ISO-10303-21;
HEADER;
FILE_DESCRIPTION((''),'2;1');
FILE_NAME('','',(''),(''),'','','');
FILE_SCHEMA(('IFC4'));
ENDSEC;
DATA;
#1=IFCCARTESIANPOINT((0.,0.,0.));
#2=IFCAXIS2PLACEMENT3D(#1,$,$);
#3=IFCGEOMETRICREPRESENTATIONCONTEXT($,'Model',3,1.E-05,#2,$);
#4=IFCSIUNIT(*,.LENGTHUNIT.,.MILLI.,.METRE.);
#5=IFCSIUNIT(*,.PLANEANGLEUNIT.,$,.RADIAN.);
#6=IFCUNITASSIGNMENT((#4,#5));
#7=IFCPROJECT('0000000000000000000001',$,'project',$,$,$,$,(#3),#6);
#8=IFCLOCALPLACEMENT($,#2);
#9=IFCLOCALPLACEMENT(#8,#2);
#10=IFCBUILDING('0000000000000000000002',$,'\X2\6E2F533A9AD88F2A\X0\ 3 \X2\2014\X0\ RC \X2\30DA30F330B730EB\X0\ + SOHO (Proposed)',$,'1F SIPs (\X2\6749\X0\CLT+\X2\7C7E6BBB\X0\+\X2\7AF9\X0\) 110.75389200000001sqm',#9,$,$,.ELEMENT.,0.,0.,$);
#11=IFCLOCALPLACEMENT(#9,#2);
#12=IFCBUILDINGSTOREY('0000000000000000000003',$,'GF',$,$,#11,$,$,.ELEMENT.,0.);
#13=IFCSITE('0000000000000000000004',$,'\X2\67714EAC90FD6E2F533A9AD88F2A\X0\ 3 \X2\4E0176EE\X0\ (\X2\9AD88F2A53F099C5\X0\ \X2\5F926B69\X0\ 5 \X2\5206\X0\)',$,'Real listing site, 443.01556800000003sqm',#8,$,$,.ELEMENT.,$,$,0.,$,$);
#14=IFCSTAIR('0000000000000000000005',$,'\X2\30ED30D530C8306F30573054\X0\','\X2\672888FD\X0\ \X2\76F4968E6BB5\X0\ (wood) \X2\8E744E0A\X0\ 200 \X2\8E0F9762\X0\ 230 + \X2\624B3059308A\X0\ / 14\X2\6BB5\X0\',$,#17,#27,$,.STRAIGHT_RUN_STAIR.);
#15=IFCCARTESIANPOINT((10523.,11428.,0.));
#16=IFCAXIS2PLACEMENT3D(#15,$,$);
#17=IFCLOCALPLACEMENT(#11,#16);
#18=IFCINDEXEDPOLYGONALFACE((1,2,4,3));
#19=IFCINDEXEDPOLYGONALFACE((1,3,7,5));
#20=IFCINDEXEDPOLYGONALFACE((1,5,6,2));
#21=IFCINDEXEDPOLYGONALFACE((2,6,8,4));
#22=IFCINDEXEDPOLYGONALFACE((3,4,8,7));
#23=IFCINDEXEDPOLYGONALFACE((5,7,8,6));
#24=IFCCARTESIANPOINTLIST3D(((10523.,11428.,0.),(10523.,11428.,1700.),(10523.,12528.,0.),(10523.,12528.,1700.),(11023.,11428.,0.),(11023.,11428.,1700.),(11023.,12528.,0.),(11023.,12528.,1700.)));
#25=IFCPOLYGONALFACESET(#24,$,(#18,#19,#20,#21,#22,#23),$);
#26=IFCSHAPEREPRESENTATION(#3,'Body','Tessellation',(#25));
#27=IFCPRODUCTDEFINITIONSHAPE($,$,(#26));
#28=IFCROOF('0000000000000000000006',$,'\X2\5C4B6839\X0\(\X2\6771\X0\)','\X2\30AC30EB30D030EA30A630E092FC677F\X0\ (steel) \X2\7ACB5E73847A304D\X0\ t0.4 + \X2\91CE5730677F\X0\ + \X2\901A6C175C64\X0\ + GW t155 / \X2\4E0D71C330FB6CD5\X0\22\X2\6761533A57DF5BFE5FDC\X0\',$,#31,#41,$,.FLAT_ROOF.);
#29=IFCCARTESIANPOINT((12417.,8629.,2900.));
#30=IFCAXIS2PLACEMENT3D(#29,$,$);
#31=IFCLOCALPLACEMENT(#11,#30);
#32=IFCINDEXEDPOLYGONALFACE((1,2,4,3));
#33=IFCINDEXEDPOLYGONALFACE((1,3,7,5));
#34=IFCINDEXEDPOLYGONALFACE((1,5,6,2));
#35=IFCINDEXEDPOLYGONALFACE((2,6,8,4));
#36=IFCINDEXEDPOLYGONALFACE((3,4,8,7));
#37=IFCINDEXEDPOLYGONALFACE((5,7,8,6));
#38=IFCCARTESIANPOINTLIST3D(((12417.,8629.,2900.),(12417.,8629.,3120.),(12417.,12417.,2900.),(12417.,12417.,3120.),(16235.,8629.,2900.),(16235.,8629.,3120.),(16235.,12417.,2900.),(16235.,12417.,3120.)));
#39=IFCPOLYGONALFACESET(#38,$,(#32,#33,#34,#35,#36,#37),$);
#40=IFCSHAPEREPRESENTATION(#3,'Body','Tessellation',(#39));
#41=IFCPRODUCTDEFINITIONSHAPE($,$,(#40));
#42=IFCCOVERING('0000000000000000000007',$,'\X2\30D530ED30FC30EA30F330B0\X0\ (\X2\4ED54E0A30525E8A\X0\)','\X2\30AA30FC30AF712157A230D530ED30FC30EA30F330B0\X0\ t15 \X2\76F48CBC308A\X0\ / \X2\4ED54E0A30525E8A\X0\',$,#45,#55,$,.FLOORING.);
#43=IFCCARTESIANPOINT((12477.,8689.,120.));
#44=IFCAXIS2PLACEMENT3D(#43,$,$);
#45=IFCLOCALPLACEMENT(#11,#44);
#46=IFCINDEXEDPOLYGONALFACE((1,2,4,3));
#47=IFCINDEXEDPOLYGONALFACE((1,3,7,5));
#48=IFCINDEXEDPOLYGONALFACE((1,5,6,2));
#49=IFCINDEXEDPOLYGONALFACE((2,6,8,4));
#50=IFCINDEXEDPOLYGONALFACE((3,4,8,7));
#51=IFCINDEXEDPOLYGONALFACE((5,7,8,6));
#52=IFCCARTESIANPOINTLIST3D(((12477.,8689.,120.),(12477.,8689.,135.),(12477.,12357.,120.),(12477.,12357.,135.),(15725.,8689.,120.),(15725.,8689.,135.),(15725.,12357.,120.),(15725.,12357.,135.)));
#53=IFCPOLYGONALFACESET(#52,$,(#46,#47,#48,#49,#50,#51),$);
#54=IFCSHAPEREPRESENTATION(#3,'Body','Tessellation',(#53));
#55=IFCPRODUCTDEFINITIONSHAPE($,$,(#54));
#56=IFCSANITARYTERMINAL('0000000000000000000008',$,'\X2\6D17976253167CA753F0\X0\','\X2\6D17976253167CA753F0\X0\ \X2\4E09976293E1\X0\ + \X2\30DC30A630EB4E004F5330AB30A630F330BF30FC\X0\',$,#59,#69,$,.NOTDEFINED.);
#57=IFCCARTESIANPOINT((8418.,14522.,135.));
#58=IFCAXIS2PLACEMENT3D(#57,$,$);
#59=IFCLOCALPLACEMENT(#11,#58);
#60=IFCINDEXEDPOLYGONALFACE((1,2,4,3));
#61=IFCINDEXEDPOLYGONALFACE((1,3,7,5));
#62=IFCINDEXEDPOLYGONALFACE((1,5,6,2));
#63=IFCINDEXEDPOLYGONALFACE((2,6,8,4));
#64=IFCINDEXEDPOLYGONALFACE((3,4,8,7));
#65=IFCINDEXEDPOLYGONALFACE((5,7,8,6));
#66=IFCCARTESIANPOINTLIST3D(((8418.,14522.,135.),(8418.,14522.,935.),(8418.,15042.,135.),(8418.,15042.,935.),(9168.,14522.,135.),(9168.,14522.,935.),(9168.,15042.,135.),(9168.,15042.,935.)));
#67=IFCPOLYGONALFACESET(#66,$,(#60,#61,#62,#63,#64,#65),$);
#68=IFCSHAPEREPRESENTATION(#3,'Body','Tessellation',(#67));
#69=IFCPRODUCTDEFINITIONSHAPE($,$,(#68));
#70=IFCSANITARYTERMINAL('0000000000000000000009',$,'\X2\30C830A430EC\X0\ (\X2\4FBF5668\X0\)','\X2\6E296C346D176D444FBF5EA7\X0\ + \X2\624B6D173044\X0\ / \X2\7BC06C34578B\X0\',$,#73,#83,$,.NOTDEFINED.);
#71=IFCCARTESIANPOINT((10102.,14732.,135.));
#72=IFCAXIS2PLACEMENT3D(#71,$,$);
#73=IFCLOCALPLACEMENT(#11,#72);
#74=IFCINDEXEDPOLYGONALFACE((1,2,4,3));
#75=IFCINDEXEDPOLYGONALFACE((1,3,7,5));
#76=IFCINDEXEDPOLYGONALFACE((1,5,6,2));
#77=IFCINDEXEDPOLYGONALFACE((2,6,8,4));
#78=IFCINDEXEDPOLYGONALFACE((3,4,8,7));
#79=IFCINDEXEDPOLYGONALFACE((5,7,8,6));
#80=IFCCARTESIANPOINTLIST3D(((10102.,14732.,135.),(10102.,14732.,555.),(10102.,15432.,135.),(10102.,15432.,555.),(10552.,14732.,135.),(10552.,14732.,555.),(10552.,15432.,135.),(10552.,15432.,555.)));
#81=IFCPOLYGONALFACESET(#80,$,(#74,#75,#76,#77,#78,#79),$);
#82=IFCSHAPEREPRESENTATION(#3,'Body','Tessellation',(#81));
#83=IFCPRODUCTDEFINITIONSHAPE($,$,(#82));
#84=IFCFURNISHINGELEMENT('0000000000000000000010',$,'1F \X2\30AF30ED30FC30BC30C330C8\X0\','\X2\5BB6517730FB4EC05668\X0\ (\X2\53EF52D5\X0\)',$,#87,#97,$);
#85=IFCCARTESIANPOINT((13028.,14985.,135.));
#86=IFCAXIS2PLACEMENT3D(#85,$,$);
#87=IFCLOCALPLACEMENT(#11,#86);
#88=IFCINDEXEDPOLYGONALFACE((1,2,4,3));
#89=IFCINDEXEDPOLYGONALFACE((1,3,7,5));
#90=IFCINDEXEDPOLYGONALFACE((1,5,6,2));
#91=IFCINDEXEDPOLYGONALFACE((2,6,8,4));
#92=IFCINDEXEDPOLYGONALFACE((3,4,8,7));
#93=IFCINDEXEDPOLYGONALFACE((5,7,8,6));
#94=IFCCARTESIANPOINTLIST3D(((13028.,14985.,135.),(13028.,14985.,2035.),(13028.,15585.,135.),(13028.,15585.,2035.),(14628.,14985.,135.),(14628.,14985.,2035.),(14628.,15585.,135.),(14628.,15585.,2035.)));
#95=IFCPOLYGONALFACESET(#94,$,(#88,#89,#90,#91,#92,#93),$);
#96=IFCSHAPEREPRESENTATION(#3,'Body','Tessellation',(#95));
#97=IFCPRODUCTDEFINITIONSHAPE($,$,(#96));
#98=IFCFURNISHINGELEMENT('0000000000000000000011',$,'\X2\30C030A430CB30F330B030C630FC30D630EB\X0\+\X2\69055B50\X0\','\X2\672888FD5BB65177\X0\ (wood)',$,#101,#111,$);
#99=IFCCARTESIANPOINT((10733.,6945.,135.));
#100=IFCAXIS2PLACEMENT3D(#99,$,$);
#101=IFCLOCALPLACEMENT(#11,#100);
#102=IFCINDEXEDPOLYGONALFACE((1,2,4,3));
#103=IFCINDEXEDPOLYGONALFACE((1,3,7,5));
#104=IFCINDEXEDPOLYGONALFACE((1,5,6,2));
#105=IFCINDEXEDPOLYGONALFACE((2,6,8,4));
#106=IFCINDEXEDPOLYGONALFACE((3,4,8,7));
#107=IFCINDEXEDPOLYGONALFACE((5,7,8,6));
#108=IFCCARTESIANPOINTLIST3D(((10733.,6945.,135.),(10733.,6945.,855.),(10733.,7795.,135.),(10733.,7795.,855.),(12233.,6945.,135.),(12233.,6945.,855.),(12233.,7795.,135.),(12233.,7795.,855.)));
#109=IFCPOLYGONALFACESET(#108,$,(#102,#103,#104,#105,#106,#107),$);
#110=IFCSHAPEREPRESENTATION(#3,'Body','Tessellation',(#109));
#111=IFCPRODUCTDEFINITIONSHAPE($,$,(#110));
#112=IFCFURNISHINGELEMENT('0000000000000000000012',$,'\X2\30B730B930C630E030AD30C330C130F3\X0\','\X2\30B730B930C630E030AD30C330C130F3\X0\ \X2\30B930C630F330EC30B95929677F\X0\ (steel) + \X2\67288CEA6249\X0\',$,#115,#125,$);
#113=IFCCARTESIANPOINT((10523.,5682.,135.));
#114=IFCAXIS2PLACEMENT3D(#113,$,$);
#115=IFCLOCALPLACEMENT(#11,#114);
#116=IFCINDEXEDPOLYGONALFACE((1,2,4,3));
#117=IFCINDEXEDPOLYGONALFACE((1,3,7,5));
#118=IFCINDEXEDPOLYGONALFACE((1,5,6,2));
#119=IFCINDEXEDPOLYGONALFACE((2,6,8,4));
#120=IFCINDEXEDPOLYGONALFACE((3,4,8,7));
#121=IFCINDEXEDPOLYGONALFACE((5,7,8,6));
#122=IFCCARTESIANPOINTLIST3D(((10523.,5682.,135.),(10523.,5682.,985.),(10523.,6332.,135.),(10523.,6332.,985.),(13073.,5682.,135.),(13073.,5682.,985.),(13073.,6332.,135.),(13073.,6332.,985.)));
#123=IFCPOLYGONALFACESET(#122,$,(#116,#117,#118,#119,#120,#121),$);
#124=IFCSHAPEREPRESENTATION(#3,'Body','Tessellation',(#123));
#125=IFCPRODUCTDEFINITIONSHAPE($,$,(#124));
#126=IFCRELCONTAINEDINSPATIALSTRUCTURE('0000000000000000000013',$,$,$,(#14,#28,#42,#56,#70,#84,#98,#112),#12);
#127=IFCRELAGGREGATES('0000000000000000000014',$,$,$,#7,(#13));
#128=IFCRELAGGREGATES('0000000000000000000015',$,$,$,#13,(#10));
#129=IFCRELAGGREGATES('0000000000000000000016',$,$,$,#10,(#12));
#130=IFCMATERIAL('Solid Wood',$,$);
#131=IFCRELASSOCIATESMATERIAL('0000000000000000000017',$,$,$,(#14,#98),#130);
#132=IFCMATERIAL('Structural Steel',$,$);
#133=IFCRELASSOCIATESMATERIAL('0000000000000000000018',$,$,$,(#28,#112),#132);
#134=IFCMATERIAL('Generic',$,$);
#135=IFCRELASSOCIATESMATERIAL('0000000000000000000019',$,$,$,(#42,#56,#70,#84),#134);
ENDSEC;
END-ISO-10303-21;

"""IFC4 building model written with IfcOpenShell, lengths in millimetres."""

from ifc_helpers import new_model, si_unit, frame, frame_2d, origin, place, context, project, spatial, rectangle, extrude, material, element, save


model = new_model("IFC4")

# Units and contexts
model_context = context("Model", 3, precision=1e-05, world=origin())
ifc_project = project(units=[si_unit("LENGTHUNIT", "METRE", prefix="MILLI"), si_unit("PLANEANGLEUNIT", "RADIAN")], contexts=[model_context])

# Site, building, storey
site_placement = place(None, origin())
site = spatial("IfcSite", under=ifc_project, at=site_placement, Name="東京都港区高輪 3 丁目 (高輪台駅 徒歩 5 分)", ObjectType="Real listing site, 443.01556800000003sqm", CompositionType="ELEMENT", RefElevation=0.0)
building_placement = place(site_placement, origin())
building = spatial("IfcBuilding", under=site, at=building_placement, Name="港区高輪 3 — RC ペンシル + SOHO (Proposed)", ObjectType="1F SIPs (杉CLT+籾殻+竹) 110.75389200000001sqm", CompositionType="ELEMENT", ElevationOfRefHeight=0.0, ElevationOfTerrain=0.0)
storey_placement = place(building_placement, origin())
storey = spatial("IfcBuildingStorey", under=building, at=storey_placement, Name="GF", CompositionType="ELEMENT", Elevation=0.0)

# Shared definitions
ifc_material_1 = material(Name="Solid Wood")

# Stair
stair_placement = place(storey_placement, frame((10523.0, 11428.0, 0.0)))
element("IfcStair", 1, at=stair_placement, inside=storey, material=ifc_material_1, Name="ロフトはしご", Description="木製 直階段 (wood) 蹴上 200 踏面 230 + 手すり / 14段", PredefinedType="STRAIGHT_RUN_STAIR", context=model_context, shape_type="SweptSolid", body=[
    extrude(rectangle(XDim=500.0, YDim=1100.0, at=frame_2d((250.0, 550.0))), frame((10523.0, 11428.0, 0.0)), (0.0, 0.0, 1.0), 1700.0),
])

# Roof
ifc_material_2 = material(Name="Structural Steel")
roof_placement = place(storey_placement, frame((12417.0, 8629.0, 2900.0)))
element("IfcRoof", 2, at=roof_placement, inside=storey, material=ifc_material_2, Name="屋根(東)", Description="ガルバリウム鋼板 (steel) 立平葺き t0.4 + 野地板 + 通気層 + GW t155 / 不燃・法22条区域対応", PredefinedType="FLAT_ROOF", context=model_context, shape_type="SweptSolid", body=[
    extrude(rectangle(XDim=3818.0, YDim=3788.0, at=frame_2d((1909.0, 1894.0))), frame((12417.0, 8629.0, 2900.0)), (0.0, 0.0, 1.0), 220.0),
])

# Covering
ifc_material_3 = material(Name="Generic")
covering_placement = place(storey_placement, frame((12477.0, 8689.0, 120.0)))
element("IfcCovering", 3, at=covering_placement, inside=storey, material=ifc_material_3, Name="フローリング (仕上げ床)", Description="オーク無垢フローリング t15 直貼り / 仕上げ床", PredefinedType="FLOORING", context=model_context, shape_type="SweptSolid", body=[
    extrude(rectangle(XDim=3248.0, YDim=3668.0, at=frame_2d((1624.0, 1834.0))), frame((12477.0, 8689.0, 120.0)), (0.0, 0.0, 1.0), 15.0),
])

# Sanitary terminals
sanitary_terminal_1_placement = place(storey_placement, frame((8418.0, 14522.0, 135.0)))
element("IfcSanitaryTerminal", 4, at=sanitary_terminal_1_placement, inside=storey, material=ifc_material_3, Name="洗面化粧台", Description="洗面化粧台 三面鏡 + ボウル一体カウンター", PredefinedType="NOTDEFINED", context=model_context, shape_type="SweptSolid", body=[
    extrude(rectangle(XDim=750.0, YDim=520.0, at=frame_2d((375.0, 260.0))), frame((8418.0, 14522.0, 135.0)), (0.0, 0.0, 1.0), 800.0),
])
sanitary_terminal_2_placement = place(storey_placement, frame((10102.0, 14732.0, 135.0)))
element("IfcSanitaryTerminal", 5, at=sanitary_terminal_2_placement, inside=storey, material=ifc_material_3, Name="トイレ (便器)", Description="温水洗浄便座 + 手洗い / 節水型", PredefinedType="NOTDEFINED", context=model_context, shape_type="SweptSolid", body=[
    extrude(rectangle(XDim=450.0, YDim=700.0, at=frame_2d((225.0, 350.0))), frame((10102.0, 14732.0, 135.0)), (0.0, 0.0, 1.0), 420.0),
])

# Furnishing elements
furnishing_1_placement = place(storey_placement, frame((13028.0, 14985.0, 135.0)))
element("IfcFurnishingElement", 6, at=furnishing_1_placement, inside=storey, material=ifc_material_3, Name="1F クローゼット", Description="家具・什器 (可動)", context=model_context, shape_type="SweptSolid", body=[
    extrude(rectangle(XDim=1600.0, YDim=600.0, at=frame_2d((800.0, 300.0))), frame((13028.0, 14985.0, 135.0)), (0.0, 0.0, 1.0), 1900.0),
])
furnishing_2_placement = place(storey_placement, frame((10733.0, 6945.0, 135.0)))
element("IfcFurnishingElement", 7, at=furnishing_2_placement, inside=storey, material=ifc_material_1, Name="ダイニングテーブル+椅子", Description="木製家具 (wood)", context=model_context, shape_type="SweptSolid", body=[
    extrude(rectangle(XDim=1500.0, YDim=850.0, at=frame_2d((750.0, 425.0))), frame((10733.0, 6945.0, 135.0)), (0.0, 0.0, 1.0), 720.0),
])
furnishing_3_placement = place(storey_placement, frame((10523.0, 5682.0, 135.0)))
element("IfcFurnishingElement", 8, at=furnishing_3_placement, inside=storey, material=ifc_material_2, Name="システムキッチン", Description="システムキッチン ステンレス天板 (steel) + 木質扉", context=model_context, shape_type="SweptSolid", body=[
    extrude(rectangle(XDim=2550.0, YDim=650.0, at=frame_2d((1275.0, 325.0))), frame((10523.0, 5682.0, 135.0)), (0.0, 0.0, 1.0), 850.0),
])

save(model, "model.ifc")
